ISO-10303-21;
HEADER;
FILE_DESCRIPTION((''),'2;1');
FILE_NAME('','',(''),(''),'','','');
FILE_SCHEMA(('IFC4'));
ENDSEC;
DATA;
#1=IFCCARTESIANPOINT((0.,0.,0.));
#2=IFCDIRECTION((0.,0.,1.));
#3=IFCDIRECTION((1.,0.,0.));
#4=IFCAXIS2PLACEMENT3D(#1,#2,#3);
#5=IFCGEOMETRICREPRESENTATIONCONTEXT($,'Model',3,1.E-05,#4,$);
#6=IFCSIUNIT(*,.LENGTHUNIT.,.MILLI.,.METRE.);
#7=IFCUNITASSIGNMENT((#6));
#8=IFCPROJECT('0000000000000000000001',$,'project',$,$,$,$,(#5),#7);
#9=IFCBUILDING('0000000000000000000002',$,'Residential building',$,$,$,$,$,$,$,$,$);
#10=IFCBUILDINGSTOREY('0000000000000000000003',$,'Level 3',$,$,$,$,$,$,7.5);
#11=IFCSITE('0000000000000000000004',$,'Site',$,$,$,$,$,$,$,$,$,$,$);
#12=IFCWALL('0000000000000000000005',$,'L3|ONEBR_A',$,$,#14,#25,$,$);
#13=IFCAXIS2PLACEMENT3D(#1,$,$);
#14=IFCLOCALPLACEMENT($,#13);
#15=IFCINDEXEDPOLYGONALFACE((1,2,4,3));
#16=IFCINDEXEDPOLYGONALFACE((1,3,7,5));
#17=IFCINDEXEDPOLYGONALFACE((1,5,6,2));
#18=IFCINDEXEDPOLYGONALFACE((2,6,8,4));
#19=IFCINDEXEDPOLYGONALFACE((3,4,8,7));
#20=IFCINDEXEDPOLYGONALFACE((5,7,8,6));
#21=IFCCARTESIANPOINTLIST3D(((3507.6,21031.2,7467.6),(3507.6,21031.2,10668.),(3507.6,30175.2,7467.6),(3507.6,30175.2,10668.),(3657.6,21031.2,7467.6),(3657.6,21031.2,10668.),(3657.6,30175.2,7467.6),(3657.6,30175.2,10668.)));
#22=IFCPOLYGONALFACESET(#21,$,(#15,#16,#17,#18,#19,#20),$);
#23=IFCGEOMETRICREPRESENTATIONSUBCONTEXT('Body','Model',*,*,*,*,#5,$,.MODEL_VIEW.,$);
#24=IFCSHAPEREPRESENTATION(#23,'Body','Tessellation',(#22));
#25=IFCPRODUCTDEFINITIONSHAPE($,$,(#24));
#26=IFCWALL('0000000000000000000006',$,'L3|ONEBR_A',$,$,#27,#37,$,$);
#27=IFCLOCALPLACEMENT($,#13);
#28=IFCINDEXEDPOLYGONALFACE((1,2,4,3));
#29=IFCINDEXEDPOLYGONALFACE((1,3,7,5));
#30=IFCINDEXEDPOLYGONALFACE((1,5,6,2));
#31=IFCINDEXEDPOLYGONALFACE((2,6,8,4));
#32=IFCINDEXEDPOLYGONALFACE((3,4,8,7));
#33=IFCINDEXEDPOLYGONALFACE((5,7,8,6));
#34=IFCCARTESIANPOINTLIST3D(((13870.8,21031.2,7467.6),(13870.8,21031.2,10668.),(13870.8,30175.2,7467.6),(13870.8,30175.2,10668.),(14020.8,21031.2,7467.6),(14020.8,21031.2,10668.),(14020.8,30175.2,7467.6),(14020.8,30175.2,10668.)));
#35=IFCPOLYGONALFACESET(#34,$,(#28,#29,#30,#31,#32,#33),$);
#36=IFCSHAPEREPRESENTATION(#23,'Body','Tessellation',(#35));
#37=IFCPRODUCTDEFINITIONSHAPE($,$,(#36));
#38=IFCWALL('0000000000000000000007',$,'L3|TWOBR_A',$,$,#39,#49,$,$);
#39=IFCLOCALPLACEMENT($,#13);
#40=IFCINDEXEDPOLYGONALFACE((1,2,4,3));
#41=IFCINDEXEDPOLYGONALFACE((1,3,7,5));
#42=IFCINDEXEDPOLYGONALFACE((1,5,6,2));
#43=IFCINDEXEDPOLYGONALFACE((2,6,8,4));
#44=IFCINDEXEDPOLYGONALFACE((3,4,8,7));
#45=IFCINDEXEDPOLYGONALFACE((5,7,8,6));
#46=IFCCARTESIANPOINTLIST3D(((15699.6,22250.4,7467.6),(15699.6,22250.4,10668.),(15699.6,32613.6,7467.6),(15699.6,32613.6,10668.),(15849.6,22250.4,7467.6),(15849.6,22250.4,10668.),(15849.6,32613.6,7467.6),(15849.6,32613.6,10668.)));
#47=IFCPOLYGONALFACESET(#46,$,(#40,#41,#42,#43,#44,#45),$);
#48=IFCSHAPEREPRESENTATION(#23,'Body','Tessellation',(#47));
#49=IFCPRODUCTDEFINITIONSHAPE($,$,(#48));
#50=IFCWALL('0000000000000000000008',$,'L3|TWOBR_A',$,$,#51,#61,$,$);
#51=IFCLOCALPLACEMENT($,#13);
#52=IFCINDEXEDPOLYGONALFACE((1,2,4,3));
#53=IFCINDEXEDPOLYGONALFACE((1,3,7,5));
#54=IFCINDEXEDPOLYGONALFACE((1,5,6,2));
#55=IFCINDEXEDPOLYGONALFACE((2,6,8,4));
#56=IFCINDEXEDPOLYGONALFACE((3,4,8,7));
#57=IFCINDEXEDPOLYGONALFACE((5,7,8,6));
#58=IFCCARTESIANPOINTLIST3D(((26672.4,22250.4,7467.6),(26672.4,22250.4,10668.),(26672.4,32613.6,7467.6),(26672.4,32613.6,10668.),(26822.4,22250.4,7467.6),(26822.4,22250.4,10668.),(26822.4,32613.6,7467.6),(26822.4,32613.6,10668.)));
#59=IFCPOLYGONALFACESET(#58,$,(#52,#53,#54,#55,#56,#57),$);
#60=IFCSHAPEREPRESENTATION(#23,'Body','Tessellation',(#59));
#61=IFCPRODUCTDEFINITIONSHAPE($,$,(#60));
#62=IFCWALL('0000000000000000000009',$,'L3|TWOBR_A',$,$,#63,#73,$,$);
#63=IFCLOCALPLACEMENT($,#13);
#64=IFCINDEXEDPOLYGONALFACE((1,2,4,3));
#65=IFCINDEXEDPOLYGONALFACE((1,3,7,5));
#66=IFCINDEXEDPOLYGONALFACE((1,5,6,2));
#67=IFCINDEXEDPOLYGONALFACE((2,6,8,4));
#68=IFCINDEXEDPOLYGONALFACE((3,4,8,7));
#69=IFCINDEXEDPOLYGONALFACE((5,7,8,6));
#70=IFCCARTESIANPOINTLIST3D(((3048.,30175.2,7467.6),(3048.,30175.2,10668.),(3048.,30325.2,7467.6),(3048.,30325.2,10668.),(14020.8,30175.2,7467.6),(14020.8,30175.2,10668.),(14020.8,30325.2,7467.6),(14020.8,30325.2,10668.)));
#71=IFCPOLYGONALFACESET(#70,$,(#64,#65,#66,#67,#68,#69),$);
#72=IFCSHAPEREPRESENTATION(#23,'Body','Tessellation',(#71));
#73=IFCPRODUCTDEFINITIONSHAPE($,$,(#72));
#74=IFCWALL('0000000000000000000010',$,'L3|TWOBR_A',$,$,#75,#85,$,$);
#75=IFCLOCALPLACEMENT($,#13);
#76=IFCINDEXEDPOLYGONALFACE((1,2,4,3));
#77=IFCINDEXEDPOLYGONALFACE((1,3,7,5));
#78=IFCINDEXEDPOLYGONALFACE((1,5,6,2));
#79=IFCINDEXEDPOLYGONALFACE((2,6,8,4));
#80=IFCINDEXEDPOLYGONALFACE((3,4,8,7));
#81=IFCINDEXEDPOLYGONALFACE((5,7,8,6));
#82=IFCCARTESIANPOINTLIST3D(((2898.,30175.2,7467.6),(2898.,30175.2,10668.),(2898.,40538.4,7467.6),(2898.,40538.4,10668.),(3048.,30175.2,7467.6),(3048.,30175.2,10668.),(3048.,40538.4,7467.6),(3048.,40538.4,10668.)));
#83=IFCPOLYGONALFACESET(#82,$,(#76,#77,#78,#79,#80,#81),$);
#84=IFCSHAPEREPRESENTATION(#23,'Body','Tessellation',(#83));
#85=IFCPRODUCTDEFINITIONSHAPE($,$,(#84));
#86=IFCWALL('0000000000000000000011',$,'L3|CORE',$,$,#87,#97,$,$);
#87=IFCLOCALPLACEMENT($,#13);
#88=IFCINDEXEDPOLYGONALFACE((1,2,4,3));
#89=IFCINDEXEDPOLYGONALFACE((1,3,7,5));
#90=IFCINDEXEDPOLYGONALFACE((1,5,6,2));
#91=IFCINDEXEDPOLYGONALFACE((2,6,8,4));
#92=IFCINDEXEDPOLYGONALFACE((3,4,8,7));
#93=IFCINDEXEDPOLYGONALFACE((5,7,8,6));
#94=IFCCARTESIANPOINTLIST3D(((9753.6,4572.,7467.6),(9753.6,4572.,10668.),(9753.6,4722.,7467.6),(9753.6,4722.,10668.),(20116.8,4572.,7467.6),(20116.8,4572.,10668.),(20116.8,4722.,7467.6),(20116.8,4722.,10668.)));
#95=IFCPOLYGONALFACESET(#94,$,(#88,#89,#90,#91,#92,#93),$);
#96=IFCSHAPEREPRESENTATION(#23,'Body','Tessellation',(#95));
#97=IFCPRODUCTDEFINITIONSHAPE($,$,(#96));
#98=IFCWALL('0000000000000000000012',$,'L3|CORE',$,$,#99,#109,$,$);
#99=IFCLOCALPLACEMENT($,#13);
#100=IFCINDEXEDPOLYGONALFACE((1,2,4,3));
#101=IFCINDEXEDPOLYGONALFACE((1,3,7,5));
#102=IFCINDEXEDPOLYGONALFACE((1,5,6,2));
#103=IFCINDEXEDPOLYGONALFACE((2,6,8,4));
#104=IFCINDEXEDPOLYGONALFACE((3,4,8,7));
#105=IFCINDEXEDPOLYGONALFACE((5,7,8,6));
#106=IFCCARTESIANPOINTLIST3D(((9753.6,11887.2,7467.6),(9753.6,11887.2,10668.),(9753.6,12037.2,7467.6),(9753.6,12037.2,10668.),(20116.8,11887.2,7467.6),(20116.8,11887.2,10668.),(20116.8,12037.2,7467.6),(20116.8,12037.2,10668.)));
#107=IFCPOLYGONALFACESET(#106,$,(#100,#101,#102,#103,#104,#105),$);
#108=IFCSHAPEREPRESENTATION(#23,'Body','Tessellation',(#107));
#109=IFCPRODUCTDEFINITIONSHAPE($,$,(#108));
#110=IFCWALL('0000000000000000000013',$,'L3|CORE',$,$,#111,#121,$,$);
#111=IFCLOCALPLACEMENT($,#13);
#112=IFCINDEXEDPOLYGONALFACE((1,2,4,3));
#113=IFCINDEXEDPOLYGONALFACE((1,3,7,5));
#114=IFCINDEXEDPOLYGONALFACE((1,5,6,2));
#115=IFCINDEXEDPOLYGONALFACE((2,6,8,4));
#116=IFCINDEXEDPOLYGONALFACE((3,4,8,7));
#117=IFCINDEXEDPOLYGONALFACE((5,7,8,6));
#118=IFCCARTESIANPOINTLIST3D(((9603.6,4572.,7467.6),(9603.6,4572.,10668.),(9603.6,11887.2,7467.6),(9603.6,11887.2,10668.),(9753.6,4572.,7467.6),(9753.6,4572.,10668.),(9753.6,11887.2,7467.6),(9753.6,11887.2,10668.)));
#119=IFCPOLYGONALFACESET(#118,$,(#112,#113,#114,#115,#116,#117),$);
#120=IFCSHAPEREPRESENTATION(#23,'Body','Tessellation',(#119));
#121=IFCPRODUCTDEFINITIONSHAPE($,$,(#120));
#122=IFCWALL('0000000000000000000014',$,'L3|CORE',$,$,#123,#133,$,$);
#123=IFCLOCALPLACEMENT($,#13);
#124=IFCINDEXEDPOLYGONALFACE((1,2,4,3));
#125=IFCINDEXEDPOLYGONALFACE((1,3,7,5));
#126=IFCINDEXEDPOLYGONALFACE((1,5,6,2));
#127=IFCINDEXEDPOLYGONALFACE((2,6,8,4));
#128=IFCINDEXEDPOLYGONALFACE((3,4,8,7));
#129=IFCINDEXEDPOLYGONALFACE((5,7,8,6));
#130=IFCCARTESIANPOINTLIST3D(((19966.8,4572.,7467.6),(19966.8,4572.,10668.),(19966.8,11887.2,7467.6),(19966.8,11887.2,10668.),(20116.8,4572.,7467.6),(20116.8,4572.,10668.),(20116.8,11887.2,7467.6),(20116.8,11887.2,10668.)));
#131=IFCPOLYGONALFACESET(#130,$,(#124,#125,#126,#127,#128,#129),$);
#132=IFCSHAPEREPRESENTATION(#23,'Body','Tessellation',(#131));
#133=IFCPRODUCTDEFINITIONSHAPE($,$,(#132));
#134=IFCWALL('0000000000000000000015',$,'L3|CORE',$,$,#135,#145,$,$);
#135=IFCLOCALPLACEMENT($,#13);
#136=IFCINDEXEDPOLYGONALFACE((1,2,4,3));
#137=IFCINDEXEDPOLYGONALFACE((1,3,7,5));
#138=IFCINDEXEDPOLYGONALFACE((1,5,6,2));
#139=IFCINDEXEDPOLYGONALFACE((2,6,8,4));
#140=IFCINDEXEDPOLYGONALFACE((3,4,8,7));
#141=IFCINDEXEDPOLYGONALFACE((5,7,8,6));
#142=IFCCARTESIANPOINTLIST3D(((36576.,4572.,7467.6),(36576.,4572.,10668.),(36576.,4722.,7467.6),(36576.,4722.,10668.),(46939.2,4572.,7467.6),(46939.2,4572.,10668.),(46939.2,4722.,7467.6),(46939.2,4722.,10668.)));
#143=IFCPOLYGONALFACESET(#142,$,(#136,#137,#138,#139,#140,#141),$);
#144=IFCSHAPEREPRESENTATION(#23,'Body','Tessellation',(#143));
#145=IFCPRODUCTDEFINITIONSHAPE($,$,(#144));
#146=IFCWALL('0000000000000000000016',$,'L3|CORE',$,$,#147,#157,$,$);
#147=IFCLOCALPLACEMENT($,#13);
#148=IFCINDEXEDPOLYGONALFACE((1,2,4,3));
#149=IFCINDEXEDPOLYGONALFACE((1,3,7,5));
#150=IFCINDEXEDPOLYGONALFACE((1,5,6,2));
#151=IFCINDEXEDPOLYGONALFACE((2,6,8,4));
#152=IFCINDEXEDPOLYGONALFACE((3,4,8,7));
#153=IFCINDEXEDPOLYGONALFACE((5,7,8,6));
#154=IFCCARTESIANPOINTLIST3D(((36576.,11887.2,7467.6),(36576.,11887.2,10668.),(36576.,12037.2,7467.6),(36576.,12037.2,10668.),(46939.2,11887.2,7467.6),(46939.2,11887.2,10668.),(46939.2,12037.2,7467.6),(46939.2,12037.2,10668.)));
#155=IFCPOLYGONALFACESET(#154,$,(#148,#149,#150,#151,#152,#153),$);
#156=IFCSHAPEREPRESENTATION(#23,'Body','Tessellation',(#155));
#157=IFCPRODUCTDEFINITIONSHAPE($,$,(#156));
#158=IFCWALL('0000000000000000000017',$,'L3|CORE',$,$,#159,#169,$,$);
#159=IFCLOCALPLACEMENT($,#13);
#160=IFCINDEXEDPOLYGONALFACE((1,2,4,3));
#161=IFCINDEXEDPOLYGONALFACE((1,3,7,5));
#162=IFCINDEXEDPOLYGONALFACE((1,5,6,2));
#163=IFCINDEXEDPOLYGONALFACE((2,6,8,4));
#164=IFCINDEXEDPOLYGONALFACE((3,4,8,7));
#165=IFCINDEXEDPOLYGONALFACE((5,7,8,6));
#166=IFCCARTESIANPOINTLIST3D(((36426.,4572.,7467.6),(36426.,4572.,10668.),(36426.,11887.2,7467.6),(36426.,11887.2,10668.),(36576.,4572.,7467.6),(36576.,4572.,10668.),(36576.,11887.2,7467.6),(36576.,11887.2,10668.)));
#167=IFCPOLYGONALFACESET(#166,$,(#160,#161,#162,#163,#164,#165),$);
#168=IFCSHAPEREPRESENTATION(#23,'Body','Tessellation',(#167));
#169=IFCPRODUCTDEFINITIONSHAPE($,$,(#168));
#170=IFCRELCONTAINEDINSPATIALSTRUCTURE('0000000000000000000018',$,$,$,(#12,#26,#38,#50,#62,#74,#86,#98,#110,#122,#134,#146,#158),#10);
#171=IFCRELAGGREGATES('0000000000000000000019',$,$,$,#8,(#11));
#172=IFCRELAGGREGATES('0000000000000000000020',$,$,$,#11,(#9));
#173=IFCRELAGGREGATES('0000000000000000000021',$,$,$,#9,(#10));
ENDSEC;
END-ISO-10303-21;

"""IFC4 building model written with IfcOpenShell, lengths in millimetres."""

from ifc_helpers import new_model, si_unit, frame, origin_with_axes, place, context, subcontext, project, spatial, indexed_curve, outline, extrude, element, save


model = new_model("IFC4")

# Units and contexts
model_context = context("Model", 3, precision=1e-05, world=origin_with_axes())
body_context = subcontext(model_context, "Body", "Model", "MODEL_VIEW")
ifc_project = project(units=[si_unit("LENGTHUNIT", "METRE", prefix="MILLI")], contexts=[model_context])

# Site, building, storey
site = spatial("IfcSite", under=ifc_project, Name="Site")
building = spatial("IfcBuilding", under=site, Name="Residential building")
storey = spatial("IfcBuildingStorey", under=building, Name="Level 3", Elevation=7.5)

# Walls
for number, where, z_axis, x_axis, name in (
    (1, (3657.6, 21031.2, 7467.6), (0.0, 0.0, 1.0), (0.0, 1.0, 0.0), "L3|ONEBR_A"),
    (2, (14020.8, 21031.2, 7467.6), (0.0, 0.0, 1.0), (0.0, 1.0, 0.0), "L3|ONEBR_A"),
):
    element("IfcWall", number, at=place(None, frame(where, z_axis=z_axis, x_axis=x_axis)), inside=storey, Name=name, context=body_context, shape_type="SweptSolid", body=[
        extrude(outline(indexed_curve([(0.0, 0.0), (0.0, 150.0), (9144.0, 150.0), (9144.0, 0.0), (0.0, 0.0)], self_intersect=False)), origin_with_axes(), (0.0, 0.0, 1.0), 3200.4),
    ])
for number, where, z_axis, x_axis, name in (
    (3, (15849.6, 22250.4, 7467.6), (0.0, 0.0, 1.0), (0.0, 1.0, 0.0), "L3|TWOBR_A"),
    (4, (26822.4, 22250.4, 7467.6), (0.0, 0.0, 1.0), (0.0, 1.0, 0.0), "L3|TWOBR_A"),
):
    element("IfcWall", number, at=place(None, frame(where, z_axis=z_axis, x_axis=x_axis)), inside=storey, Name=name, context=body_context, shape_type="SweptSolid", body=[
        extrude(outline(indexed_curve([(0.0, 0.0), (0.0, 150.0), (10363.2, 150.0), (10363.2, 0.0), (0.0, 0.0)], self_intersect=False)), origin_with_axes(), (0.0, 0.0, 1.0), 3200.4),
    ])
wall_1_placement = place(None, frame((3048.0, 30175.2, 7467.6), z_axis=(0.0, 0.0, 1.0), x_axis=(1.0, 0.0, 0.0)))
element("IfcWall", 5, at=wall_1_placement, inside=storey, Name="L3|TWOBR_A", context=body_context, shape_type="SweptSolid", body=[
    extrude(outline(indexed_curve([(0.0, 0.0), (0.0, 150.0), (10972.8, 150.0), (10972.8, 0.0), (0.0, 0.0)], self_intersect=False)), origin_with_axes(), (0.0, 0.0, 1.0), 3200.4),
])
for number, where, z_axis, x_axis, name in (
    (6, (3048.0, 30175.2, 7467.6), (0.0, 0.0, 1.0), (0.0, 1.0, 0.0), "L3|TWOBR_A"),
    (7, (9753.6, 4572.0, 7467.6), (0.0, 0.0, 1.0), (1.0, 0.0, 0.0), "L3|CORE"),
    (8, (9753.6, 11887.2, 7467.6), (0.0, 0.0, 1.0), (1.0, 0.0, 0.0), "L3|CORE"),
):
    element("IfcWall", number, at=place(None, frame(where, z_axis=z_axis, x_axis=x_axis)), inside=storey, Name=name, context=body_context, shape_type="SweptSolid", body=[
        extrude(outline(indexed_curve([(0.0, 0.0), (0.0, 150.0), (10363.2, 150.0), (10363.2, 0.0), (0.0, 0.0)], self_intersect=False)), origin_with_axes(), (0.0, 0.0, 1.0), 3200.4),
    ])
for number, where, z_axis, x_axis, name in (
    (9, (9753.6, 4572.0, 7467.6), (0.0, 0.0, 1.0), (0.0, 1.0, 0.0), "L3|CORE"),
    (10, (20116.8, 4572.0, 7467.6), (0.0, 0.0, 1.0), (0.0, 1.0, 0.0), "L3|CORE"),
):
    element("IfcWall", number, at=place(None, frame(where, z_axis=z_axis, x_axis=x_axis)), inside=storey, Name=name, context=body_context, shape_type="SweptSolid", body=[
        extrude(outline(indexed_curve([(0.0, 0.0), (0.0, 150.0), (7315.2, 150.0), (7315.2, 0.0), (0.0, 0.0)], self_intersect=False)), origin_with_axes(), (0.0, 0.0, 1.0), 3200.4),
    ])
for number, where, z_axis, x_axis, name in (
    (11, (36576.0, 4572.0, 7467.6), (0.0, 0.0, 1.0), (1.0, 0.0, 0.0), "L3|CORE"),
    (12, (36576.0, 11887.2, 7467.6), (0.0, 0.0, 1.0), (1.0, 0.0, 0.0), "L3|CORE"),
):
    element("IfcWall", number, at=place(None, frame(where, z_axis=z_axis, x_axis=x_axis)), inside=storey, Name=name, context=body_context, shape_type="SweptSolid", body=[
        extrude(outline(indexed_curve([(0.0, 0.0), (0.0, 150.0), (10363.2, 150.0), (10363.2, 0.0), (0.0, 0.0)], self_intersect=False)), origin_with_axes(), (0.0, 0.0, 1.0), 3200.4),
    ])
wall_2_placement = place(None, frame((36576.0, 4572.0, 7467.6), z_axis=(0.0, 0.0, 1.0), x_axis=(0.0, 1.0, 0.0)))
element("IfcWall", 13, at=wall_2_placement, inside=storey, Name="L3|CORE", context=body_context, shape_type="SweptSolid", body=[
    extrude(outline(indexed_curve([(0.0, 0.0), (0.0, 150.0), (7315.2, 150.0), (7315.2, 0.0), (0.0, 0.0)], self_intersect=False)), origin_with_axes(), (0.0, 0.0, 1.0), 3200.4),
])

save(model, "model.ifc")
